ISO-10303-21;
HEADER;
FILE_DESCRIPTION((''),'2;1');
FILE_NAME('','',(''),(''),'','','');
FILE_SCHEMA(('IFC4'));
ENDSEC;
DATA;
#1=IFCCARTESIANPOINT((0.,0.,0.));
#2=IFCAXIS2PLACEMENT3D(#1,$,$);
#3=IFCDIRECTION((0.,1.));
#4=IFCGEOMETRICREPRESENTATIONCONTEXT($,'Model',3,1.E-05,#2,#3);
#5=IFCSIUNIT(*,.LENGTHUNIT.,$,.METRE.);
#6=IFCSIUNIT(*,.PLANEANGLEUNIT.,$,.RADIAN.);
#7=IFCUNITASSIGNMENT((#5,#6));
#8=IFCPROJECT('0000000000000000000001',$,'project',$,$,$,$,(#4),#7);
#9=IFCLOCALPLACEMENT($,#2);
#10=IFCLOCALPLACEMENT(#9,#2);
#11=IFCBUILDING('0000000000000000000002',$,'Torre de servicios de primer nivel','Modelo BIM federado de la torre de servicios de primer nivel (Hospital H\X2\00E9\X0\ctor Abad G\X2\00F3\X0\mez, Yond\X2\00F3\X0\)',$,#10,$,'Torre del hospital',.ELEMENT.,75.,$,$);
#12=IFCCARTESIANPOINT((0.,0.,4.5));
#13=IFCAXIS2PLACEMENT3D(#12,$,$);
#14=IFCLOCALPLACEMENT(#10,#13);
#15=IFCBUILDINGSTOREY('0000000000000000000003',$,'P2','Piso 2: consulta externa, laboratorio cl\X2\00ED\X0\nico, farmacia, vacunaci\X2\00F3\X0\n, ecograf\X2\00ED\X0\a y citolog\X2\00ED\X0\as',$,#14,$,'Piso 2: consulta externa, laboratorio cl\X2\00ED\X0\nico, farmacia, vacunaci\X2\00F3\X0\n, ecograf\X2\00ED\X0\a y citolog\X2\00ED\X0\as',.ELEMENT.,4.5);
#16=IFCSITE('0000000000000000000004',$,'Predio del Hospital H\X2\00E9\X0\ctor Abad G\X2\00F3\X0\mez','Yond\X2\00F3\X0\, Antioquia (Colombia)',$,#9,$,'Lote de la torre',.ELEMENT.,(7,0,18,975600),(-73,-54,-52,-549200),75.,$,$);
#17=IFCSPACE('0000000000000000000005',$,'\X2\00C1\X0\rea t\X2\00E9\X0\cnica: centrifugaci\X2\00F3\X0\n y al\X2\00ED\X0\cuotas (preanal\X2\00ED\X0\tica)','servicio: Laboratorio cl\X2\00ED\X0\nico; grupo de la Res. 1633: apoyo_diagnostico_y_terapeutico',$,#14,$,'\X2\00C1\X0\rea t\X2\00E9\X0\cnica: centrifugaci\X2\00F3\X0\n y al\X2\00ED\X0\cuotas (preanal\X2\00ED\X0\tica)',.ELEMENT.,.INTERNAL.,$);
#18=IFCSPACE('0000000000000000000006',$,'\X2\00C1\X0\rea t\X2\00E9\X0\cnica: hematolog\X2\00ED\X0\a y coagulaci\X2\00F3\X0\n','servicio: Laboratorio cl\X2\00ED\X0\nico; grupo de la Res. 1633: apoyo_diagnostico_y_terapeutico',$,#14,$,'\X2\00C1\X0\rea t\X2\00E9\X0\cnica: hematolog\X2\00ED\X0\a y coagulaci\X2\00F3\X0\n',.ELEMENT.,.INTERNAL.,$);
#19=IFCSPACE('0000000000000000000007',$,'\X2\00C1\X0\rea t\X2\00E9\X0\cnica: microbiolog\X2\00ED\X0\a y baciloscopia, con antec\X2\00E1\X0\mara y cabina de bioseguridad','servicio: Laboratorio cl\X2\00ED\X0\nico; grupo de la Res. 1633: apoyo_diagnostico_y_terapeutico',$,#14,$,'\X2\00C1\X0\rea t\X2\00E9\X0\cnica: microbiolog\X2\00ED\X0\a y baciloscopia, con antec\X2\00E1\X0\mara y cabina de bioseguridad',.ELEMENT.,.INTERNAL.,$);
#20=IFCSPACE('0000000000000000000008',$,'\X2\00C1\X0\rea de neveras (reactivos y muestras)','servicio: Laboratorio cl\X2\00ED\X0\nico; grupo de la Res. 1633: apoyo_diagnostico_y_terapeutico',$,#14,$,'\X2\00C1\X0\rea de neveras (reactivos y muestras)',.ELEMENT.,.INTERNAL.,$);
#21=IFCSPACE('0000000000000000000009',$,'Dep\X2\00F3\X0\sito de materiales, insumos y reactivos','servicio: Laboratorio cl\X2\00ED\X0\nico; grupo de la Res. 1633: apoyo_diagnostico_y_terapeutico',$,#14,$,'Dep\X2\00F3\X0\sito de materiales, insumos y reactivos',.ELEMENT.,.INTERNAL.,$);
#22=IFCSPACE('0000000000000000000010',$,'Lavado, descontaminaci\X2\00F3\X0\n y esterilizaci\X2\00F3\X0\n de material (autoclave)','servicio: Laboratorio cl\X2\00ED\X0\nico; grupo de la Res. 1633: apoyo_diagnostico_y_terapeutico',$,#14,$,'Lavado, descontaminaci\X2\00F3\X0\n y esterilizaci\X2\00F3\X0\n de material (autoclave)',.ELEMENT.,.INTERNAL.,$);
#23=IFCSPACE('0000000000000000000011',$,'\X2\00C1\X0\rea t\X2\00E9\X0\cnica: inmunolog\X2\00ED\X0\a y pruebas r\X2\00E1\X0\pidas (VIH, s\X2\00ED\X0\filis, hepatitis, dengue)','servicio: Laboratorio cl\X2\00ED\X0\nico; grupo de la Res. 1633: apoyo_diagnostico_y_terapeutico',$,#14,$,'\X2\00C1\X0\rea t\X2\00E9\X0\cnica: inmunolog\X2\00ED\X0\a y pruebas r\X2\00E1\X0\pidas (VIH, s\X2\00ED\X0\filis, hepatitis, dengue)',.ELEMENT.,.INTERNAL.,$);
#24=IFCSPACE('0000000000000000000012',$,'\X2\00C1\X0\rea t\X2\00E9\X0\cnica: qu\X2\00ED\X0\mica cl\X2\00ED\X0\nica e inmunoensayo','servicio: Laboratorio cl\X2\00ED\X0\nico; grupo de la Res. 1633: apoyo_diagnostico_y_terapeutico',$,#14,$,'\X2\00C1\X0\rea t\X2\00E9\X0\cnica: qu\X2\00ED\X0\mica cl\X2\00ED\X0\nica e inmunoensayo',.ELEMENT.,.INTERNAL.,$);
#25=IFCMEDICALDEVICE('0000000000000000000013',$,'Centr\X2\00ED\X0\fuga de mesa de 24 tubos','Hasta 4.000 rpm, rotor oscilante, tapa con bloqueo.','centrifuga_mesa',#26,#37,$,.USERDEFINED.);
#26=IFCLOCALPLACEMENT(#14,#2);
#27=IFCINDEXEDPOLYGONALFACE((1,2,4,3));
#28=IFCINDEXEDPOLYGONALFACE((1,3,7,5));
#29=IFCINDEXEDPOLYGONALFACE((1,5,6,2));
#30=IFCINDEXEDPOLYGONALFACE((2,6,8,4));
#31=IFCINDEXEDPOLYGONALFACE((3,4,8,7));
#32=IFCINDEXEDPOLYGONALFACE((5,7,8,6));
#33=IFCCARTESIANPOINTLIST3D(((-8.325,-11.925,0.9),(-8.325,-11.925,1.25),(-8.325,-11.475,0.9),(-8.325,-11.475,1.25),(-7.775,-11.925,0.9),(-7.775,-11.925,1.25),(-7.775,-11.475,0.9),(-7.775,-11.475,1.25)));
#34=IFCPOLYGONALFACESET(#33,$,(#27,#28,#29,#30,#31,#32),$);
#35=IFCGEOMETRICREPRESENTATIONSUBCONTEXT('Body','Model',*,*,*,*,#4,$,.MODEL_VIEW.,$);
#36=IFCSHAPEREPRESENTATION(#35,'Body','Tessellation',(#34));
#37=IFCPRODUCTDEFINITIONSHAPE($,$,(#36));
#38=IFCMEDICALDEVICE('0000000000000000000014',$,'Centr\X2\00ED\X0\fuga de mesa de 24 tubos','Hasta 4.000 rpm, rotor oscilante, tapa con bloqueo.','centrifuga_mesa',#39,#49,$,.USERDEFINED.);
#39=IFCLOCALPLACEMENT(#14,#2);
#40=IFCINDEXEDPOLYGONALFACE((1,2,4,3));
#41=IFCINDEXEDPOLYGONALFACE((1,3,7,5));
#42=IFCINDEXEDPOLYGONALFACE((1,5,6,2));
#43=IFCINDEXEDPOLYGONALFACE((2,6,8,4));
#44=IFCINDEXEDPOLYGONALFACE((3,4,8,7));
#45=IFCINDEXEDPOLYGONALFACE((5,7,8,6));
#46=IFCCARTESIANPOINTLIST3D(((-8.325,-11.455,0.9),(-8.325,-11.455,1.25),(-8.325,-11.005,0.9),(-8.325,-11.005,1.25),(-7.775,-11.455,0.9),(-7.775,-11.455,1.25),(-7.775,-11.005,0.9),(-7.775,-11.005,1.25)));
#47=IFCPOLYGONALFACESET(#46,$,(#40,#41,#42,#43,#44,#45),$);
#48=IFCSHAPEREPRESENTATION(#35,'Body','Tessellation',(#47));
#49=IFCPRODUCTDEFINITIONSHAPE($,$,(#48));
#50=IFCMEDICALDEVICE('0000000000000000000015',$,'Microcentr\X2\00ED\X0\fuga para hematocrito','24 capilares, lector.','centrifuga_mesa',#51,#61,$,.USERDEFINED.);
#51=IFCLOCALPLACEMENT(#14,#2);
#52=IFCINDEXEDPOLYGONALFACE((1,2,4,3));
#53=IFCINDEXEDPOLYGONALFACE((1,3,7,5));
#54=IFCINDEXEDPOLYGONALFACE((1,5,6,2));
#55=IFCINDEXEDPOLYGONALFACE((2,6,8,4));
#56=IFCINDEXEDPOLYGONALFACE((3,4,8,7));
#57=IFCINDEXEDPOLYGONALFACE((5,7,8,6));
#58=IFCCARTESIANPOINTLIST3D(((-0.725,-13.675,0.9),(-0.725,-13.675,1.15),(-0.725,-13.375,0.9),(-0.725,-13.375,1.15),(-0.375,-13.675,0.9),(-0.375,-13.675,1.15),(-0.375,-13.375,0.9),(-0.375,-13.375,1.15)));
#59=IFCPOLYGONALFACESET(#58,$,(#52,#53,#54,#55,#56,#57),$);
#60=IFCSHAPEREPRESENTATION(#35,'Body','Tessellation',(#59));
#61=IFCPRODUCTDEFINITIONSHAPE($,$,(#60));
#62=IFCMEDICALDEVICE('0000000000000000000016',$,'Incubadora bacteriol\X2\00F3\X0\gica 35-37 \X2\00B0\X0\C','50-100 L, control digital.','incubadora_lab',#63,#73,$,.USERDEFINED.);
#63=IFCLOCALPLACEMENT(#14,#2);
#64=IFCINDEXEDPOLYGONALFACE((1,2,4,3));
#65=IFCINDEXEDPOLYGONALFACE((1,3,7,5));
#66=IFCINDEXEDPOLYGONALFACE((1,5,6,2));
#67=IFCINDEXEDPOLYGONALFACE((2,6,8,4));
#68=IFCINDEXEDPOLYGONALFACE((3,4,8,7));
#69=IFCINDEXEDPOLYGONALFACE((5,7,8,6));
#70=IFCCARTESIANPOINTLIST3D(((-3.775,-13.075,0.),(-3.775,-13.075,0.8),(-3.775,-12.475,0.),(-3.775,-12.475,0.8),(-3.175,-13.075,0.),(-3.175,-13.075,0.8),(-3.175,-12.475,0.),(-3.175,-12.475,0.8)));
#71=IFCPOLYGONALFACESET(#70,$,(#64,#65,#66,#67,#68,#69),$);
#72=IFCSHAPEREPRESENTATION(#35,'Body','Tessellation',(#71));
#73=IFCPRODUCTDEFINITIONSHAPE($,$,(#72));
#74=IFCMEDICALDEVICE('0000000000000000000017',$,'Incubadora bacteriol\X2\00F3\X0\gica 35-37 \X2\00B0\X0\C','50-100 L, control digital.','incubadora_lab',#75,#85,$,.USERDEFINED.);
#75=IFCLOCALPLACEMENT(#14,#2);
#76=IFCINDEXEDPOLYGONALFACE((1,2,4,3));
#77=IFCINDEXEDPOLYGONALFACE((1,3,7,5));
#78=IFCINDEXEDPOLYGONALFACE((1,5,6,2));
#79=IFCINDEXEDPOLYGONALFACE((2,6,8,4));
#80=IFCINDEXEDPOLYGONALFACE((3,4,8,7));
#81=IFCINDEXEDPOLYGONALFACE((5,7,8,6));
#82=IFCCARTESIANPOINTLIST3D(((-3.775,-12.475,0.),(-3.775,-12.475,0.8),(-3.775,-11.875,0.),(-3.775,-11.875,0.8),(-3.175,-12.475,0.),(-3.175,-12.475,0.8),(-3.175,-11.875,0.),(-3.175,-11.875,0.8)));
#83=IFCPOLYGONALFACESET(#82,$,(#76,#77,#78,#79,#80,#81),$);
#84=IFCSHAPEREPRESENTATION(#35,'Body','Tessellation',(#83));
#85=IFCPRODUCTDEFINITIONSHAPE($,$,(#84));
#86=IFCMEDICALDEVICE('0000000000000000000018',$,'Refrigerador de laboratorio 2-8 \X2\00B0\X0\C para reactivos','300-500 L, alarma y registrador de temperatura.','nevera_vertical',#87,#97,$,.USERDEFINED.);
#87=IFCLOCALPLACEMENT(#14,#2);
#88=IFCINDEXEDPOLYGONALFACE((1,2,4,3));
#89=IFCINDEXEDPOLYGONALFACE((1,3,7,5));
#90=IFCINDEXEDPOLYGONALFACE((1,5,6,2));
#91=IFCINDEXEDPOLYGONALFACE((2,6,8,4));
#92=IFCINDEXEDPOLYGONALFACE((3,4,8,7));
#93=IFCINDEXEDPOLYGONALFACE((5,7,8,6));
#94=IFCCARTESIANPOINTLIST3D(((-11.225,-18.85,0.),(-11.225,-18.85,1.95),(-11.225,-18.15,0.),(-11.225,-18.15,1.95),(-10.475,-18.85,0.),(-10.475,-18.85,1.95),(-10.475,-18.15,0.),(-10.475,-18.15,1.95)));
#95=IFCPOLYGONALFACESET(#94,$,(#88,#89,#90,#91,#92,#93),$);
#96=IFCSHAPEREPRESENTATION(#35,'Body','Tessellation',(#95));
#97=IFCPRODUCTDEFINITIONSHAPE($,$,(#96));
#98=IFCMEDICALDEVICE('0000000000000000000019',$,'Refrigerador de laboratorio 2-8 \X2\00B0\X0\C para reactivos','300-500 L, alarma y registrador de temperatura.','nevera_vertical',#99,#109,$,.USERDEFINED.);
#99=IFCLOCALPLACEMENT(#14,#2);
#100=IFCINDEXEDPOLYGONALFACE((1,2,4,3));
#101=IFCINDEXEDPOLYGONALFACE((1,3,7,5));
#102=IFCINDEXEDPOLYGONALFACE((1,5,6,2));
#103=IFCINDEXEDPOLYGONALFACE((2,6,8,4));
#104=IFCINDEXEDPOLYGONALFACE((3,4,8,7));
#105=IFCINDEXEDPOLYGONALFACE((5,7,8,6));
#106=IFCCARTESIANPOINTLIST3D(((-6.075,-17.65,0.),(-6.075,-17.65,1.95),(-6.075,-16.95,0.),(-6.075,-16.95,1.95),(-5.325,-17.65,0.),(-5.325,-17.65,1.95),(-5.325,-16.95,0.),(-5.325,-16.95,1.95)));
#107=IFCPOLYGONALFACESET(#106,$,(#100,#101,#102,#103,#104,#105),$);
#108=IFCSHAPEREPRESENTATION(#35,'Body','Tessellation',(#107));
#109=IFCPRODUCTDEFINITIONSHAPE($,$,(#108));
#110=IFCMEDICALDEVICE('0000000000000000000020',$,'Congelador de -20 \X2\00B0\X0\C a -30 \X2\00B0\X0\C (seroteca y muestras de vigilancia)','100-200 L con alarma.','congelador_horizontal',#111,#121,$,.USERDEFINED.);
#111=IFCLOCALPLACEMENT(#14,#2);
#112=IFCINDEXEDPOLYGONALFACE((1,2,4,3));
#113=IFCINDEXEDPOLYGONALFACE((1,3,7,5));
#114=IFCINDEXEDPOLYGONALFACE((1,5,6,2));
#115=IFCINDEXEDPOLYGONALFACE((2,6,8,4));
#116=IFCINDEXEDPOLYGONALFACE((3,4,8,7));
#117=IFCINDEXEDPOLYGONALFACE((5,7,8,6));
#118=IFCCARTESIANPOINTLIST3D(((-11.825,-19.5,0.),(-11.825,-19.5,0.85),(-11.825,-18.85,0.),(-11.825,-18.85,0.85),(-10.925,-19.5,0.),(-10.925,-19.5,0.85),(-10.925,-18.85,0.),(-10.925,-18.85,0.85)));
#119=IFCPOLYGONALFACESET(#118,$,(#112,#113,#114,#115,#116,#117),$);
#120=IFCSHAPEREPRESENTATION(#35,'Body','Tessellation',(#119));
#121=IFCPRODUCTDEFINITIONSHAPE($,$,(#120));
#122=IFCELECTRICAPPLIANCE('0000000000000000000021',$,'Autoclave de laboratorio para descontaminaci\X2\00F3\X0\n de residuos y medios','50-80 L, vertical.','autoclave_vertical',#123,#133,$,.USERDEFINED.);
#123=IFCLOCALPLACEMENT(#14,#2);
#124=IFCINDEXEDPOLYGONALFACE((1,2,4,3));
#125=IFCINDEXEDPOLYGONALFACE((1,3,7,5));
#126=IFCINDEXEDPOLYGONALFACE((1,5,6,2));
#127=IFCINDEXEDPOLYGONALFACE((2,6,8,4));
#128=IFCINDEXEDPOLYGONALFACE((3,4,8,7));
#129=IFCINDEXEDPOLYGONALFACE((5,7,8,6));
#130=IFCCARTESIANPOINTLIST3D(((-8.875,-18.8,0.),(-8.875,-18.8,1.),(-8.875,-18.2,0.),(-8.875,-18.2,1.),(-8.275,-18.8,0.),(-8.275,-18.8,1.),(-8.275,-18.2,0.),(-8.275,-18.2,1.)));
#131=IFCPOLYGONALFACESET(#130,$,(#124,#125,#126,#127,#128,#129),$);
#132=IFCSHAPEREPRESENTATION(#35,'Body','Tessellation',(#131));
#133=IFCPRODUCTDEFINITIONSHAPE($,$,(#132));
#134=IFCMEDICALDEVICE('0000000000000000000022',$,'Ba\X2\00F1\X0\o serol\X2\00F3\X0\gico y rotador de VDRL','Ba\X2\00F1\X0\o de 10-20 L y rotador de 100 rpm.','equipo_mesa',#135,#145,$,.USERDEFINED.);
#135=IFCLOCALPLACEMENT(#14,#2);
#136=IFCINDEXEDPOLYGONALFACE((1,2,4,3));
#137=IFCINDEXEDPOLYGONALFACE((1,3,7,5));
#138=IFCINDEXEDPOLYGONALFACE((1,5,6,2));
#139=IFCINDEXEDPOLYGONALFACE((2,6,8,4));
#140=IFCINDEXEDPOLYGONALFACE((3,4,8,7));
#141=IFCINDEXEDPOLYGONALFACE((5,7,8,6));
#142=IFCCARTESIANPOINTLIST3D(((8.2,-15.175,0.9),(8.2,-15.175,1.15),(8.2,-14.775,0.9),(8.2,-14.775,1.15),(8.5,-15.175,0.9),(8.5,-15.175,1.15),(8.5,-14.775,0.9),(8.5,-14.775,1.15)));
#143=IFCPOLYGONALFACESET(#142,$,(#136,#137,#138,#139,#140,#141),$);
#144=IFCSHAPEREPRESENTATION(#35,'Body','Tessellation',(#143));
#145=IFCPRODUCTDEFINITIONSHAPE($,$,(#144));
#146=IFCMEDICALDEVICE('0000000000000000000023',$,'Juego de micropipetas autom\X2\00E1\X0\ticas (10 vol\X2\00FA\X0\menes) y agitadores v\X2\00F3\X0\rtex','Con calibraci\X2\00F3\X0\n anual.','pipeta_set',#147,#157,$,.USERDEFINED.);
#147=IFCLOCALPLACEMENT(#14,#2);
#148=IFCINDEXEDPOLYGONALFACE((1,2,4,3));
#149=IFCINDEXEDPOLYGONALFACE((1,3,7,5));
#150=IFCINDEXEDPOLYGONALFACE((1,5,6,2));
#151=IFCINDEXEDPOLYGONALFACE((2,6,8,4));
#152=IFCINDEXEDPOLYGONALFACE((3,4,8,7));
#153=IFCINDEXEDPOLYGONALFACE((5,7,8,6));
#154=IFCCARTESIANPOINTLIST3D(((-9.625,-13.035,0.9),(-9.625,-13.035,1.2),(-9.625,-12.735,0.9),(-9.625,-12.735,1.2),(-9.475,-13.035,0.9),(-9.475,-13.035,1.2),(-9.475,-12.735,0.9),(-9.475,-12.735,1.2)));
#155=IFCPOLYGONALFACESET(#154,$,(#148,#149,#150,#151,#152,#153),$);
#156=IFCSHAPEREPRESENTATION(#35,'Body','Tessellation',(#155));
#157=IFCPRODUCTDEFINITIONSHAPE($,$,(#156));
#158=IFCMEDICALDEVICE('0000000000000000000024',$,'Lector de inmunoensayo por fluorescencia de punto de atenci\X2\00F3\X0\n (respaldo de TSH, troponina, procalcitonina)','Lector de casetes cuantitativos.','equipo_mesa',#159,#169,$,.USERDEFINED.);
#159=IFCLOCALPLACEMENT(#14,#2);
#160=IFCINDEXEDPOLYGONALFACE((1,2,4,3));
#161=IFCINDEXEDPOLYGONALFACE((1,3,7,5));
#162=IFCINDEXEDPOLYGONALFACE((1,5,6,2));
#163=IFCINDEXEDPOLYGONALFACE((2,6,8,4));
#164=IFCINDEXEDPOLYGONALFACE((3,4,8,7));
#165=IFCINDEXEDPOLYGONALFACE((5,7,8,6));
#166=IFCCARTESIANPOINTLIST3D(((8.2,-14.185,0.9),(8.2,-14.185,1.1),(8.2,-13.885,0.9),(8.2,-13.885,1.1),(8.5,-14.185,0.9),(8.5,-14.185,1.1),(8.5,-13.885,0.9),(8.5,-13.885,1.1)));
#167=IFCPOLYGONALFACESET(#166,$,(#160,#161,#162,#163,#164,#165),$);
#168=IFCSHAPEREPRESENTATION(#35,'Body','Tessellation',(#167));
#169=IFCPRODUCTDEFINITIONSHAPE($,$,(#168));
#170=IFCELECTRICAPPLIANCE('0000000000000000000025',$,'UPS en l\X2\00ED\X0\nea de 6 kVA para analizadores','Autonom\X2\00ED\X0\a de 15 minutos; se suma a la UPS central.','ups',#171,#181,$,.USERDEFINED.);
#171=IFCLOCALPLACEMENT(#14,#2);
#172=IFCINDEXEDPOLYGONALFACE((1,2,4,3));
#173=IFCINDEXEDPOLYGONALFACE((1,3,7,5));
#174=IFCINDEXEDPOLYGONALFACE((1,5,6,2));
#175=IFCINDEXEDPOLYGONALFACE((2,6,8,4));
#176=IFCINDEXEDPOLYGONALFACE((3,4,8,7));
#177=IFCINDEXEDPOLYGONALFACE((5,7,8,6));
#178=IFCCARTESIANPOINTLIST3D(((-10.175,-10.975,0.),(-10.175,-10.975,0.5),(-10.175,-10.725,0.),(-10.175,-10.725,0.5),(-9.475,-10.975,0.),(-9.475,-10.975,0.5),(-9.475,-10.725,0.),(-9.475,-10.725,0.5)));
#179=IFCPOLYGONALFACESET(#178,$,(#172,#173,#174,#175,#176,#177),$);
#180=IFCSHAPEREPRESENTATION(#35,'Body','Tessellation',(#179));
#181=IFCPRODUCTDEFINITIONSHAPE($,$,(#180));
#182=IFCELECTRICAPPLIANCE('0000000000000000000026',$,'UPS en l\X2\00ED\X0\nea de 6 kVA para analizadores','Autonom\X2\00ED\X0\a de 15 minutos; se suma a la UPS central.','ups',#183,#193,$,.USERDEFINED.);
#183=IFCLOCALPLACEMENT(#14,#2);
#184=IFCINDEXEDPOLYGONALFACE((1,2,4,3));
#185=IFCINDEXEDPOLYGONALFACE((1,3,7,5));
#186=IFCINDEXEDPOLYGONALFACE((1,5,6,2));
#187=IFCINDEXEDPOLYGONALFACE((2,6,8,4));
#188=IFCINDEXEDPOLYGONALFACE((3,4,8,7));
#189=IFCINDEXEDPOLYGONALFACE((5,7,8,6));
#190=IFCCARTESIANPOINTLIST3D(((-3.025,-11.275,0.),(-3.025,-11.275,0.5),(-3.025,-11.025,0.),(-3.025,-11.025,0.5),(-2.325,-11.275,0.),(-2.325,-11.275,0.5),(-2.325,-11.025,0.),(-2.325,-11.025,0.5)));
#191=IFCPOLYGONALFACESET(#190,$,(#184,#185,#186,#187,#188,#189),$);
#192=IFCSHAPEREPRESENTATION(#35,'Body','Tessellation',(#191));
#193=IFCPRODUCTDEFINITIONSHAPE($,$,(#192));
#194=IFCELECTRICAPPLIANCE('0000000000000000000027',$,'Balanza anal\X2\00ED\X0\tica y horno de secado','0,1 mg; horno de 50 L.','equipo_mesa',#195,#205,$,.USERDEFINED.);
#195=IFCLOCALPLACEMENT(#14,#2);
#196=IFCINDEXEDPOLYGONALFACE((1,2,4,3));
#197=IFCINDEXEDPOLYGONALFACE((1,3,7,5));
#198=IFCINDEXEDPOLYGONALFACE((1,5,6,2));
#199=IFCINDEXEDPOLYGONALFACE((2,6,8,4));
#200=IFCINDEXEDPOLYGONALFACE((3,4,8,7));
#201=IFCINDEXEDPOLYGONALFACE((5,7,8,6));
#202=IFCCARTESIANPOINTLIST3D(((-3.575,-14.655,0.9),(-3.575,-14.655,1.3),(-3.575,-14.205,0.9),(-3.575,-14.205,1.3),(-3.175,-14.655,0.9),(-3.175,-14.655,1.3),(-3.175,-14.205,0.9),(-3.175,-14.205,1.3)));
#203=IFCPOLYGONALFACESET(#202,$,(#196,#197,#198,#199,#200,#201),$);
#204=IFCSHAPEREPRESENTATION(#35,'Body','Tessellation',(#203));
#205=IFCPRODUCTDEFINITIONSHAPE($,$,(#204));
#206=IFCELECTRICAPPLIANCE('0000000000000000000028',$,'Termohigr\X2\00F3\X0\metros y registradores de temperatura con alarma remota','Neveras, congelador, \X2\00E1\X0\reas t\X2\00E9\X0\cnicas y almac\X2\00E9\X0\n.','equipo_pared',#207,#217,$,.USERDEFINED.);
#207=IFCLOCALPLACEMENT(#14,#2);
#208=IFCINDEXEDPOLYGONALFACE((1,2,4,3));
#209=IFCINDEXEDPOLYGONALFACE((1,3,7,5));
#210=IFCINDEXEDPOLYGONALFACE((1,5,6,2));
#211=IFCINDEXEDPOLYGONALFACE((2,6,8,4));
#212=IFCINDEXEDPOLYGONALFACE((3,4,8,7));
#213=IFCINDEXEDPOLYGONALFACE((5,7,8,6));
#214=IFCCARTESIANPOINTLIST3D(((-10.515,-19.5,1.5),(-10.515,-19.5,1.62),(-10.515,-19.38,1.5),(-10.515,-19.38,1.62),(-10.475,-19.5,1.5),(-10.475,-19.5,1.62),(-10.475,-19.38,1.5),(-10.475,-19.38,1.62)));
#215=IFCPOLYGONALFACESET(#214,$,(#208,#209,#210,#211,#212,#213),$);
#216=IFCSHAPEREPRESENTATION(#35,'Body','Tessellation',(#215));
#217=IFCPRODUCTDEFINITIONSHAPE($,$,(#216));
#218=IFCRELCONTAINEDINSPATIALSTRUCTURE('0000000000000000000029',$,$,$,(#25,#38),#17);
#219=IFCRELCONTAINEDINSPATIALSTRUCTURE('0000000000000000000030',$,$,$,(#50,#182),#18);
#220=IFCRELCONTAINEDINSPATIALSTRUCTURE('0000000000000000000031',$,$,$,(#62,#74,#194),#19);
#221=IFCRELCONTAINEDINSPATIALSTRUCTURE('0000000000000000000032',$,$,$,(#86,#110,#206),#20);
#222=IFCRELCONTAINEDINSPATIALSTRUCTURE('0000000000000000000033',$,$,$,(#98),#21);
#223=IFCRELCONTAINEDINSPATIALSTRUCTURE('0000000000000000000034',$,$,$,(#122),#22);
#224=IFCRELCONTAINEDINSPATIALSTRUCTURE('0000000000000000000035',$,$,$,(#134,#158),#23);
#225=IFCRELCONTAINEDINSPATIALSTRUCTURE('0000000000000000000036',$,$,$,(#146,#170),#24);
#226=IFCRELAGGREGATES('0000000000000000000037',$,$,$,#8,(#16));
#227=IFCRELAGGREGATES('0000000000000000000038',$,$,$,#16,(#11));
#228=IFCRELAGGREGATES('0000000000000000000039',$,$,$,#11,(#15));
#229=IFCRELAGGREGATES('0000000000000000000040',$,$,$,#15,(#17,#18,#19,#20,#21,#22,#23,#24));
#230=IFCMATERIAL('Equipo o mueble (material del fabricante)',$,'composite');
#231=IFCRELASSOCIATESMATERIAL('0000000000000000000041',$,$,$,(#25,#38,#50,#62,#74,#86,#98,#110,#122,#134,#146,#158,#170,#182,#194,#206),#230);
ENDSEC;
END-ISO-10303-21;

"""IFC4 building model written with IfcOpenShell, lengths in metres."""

from ifc_helpers import new_model, si_unit, direction, frame, origin, place, context, subcontext, project, spatial, rectangle, extrude, material, element, save


model = new_model("IFC4")

# Units and contexts
model_context = context("Model", 3, precision=1e-05, world=origin(), true_north=direction((0.0, 1.0)))
body_context = subcontext(model_context, "Body", "Model", "MODEL_VIEW")
ifc_project = project(units=[si_unit("LENGTHUNIT", "METRE"), si_unit("PLANEANGLEUNIT", "RADIAN")], contexts=[model_context])

# Site, building, storey, space
site_placement = place(None, origin())
site = spatial("IfcSite", under=ifc_project, at=site_placement, Name="Predio del Hospital Héctor Abad Gómez", Description="Yondó, Antioquia (Colombia)", LongName="Lote de la torre", CompositionType="ELEMENT", RefLatitude=(7, 0, 18, 975600), RefLongitude=(-73, -54, -52, -549200), RefElevation=75.0)
building_placement = place(site_placement, origin())
building = spatial("IfcBuilding", under=site, at=building_placement, Name="Torre de servicios de primer nivel", Description="Modelo BIM federado de la torre de servicios de primer nivel (Hospital Héctor Abad Gómez, Yondó)", LongName="Torre del hospital", CompositionType="ELEMENT", ElevationOfRefHeight=75.0)
placement = place(building_placement, frame((0.0, 0.0, 4.5)))
storey = spatial("IfcBuildingStorey", under=building, at=placement, Name="P2", Description="Piso 2: consulta externa, laboratorio clínico, farmacia, vacunación, ecografía y citologías", LongName="Piso 2: consulta externa, laboratorio clínico, farmacia, vacunación, ecografía y citologías", CompositionType="ELEMENT", Elevation=4.5)
space_1 = spatial("IfcSpace", under=storey, at=placement, Name="Área técnica: centrifugación y alícuotas (preanalítica)", Description="servicio: Laboratorio clínico; grupo de la Res. 1633: apoyo_diagnostico_y_terapeutico", LongName="Área técnica: centrifugación y alícuotas (preanalítica)", CompositionType="ELEMENT", PredefinedType="INTERNAL")

# Medical devices
ifc_material = material(Name="Equipo o mueble (material del fabricante)", Category="composite")
element("IfcMedicalDevice", 1, at=placement, inside=space_1, material=ifc_material, Name="Centrífuga de mesa de 24 tubos", Description="Hasta 4.000 rpm, rotor oscilante, tapa con bloqueo.", ObjectType="centrifuga_mesa", PredefinedType="USERDEFINED", context=body_context, shape_type="SweptSolid", body=[
    extrude(rectangle(XDim=0.45, YDim=0.55), frame((-8.05, -11.7, 0.9), z_axis=(0.0, 0.0, 1.0), x_axis=(0.0, 1.0, 0.0)), (0.0, 0.0, 1.0), 0.35),
])
element("IfcMedicalDevice", 2, at=placement, inside=space_1, material=ifc_material, Name="Centrífuga de mesa de 24 tubos", Description="Hasta 4.000 rpm, rotor oscilante, tapa con bloqueo.", ObjectType="centrifuga_mesa", PredefinedType="USERDEFINED", context=body_context, shape_type="SweptSolid", body=[
    extrude(rectangle(XDim=0.45, YDim=0.55), frame((-8.05, -11.23, 0.9), z_axis=(0.0, 0.0, 1.0), x_axis=(0.0, 1.0, 0.0)), (0.0, 0.0, 1.0), 0.35),
])

# Shared definitions
space_2 = spatial("IfcSpace", under=storey, at=placement, Name="Área técnica: hematología y coagulación", Description="servicio: Laboratorio clínico; grupo de la Res. 1633: apoyo_diagnostico_y_terapeutico", LongName="Área técnica: hematología y coagulación", CompositionType="ELEMENT", PredefinedType="INTERNAL")

# Medical device
element("IfcMedicalDevice", 3, at=placement, inside=space_2, material=ifc_material, Name="Microcentrífuga para hematocrito", Description="24 capilares, lector.", ObjectType="centrifuga_mesa", PredefinedType="USERDEFINED", context=body_context, shape_type="SweptSolid", body=[
    extrude(rectangle(XDim=0.3, YDim=0.35), frame((-0.55, -13.525, 0.9), z_axis=(0.0, 0.0, 1.0), x_axis=(0.0, 1.0, 0.0)), (0.0, 0.0, 1.0), 0.25),
])

# Shared definitions
space_3 = spatial("IfcSpace", under=storey, at=placement, Name="Área técnica: microbiología y baciloscopia, con antecámara y cabina de bioseguridad", Description="servicio: Laboratorio clínico; grupo de la Res. 1633: apoyo_diagnostico_y_terapeutico", LongName="Área técnica: microbiología y baciloscopia, con antecámara y cabina de bioseguridad", CompositionType="ELEMENT", PredefinedType="INTERNAL")

# Medical devices
element("IfcMedicalDevice", 4, at=placement, inside=space_3, material=ifc_material, Name="Incubadora bacteriológica 35-37 °C", Description="50-100 L, control digital.", ObjectType="incubadora_lab", PredefinedType="USERDEFINED", context=body_context, shape_type="SweptSolid", body=[
    extrude(rectangle(XDim=0.6, YDim=0.6), frame((-3.475, -12.775, 0.0), z_axis=(0.0, 0.0, 1.0), x_axis=(0.0, 1.0, 0.0)), (0.0, 0.0, 1.0), 0.8),
])
element("IfcMedicalDevice", 5, at=placement, inside=space_3, material=ifc_material, Name="Incubadora bacteriológica 35-37 °C", Description="50-100 L, control digital.", ObjectType="incubadora_lab", PredefinedType="USERDEFINED", context=body_context, shape_type="SweptSolid", body=[
    extrude(rectangle(XDim=0.6, YDim=0.6), frame((-3.475, -12.175, 0.0), z_axis=(0.0, 0.0, 1.0), x_axis=(0.0, 1.0, 0.0)), (0.0, 0.0, 1.0), 0.8),
])

# Shared definitions
space_4 = spatial("IfcSpace", under=storey, at=placement, Name="Área de neveras (reactivos y muestras)", Description="servicio: Laboratorio clínico; grupo de la Res. 1633: apoyo_diagnostico_y_terapeutico", LongName="Área de neveras (reactivos y muestras)", CompositionType="ELEMENT", PredefinedType="INTERNAL")

# Medical device
element("IfcMedicalDevice", 6, at=placement, inside=space_4, material=ifc_material, Name="Refrigerador de laboratorio 2-8 °C para reactivos", Description="300-500 L, alarma y registrador de temperatura.", ObjectType="nevera_vertical", PredefinedType="USERDEFINED", context=body_context, shape_type="SweptSolid", body=[
    extrude(rectangle(XDim=0.7, YDim=0.75), frame((-10.85, -18.5, 0.0), z_axis=(0.0, 0.0, 1.0), x_axis=(0.0, 1.0, 0.0)), (0.0, 0.0, 1.0), 1.95),
])

# Shared definitions
space_5 = spatial("IfcSpace", under=storey, at=placement, Name="Depósito de materiales, insumos y reactivos", Description="servicio: Laboratorio clínico; grupo de la Res. 1633: apoyo_diagnostico_y_terapeutico", LongName="Depósito de materiales, insumos y reactivos", CompositionType="ELEMENT", PredefinedType="INTERNAL")

# Medical devices
element("IfcMedicalDevice", 7, at=placement, inside=space_5, material=ifc_material, Name="Refrigerador de laboratorio 2-8 °C para reactivos", Description="300-500 L, alarma y registrador de temperatura.", ObjectType="nevera_vertical", PredefinedType="USERDEFINED", context=body_context, shape_type="SweptSolid", body=[
    extrude(rectangle(XDim=0.7, YDim=0.75), frame((-5.7, -17.3, 0.0), z_axis=(0.0, 0.0, 1.0), x_axis=(0.0, 1.0, 0.0)), (0.0, 0.0, 1.0), 1.95),
])
element("IfcMedicalDevice", 8, at=placement, inside=space_4, material=ifc_material, Name="Congelador de -20 °C a -30 °C (seroteca y muestras de vigilancia)", Description="100-200 L con alarma.", ObjectType="congelador_horizontal", PredefinedType="USERDEFINED", context=body_context, shape_type="SweptSolid", body=[
    extrude(rectangle(XDim=0.9, YDim=0.65), frame((-11.375, -19.175, 0.0)), (0.0, 0.0, 1.0), 0.85),
])

# Shared definitions
space_6 = spatial("IfcSpace", under=storey, at=placement, Name="Lavado, descontaminación y esterilización de material (autoclave)", Description="servicio: Laboratorio clínico; grupo de la Res. 1633: apoyo_diagnostico_y_terapeutico", LongName="Lavado, descontaminación y esterilización de material (autoclave)", CompositionType="ELEMENT", PredefinedType="INTERNAL")

# Electric appliance
element("IfcElectricAppliance", 9, at=placement, inside=space_6, material=ifc_material, Name="Autoclave de laboratorio para descontaminación de residuos y medios", Description="50-80 L, vertical.", ObjectType="autoclave_vertical", PredefinedType="USERDEFINED", context=body_context, shape_type="SweptSolid", body=[
    extrude(rectangle(XDim=0.6, YDim=0.6), frame((-8.575, -18.5, 0.0), z_axis=(0.0, 0.0, 1.0), x_axis=(0.0, 1.0, 0.0)), (0.0, 0.0, 1.0), 1.0),
])

# Shared definitions
space_7 = spatial("IfcSpace", under=storey, at=placement, Name="Área técnica: inmunología y pruebas rápidas (VIH, sífilis, hepatitis, dengue)", Description="servicio: Laboratorio clínico; grupo de la Res. 1633: apoyo_diagnostico_y_terapeutico", LongName="Área técnica: inmunología y pruebas rápidas (VIH, sífilis, hepatitis, dengue)", CompositionType="ELEMENT", PredefinedType="INTERNAL")

# Medical device
element("IfcMedicalDevice", 10, at=placement, inside=space_7, material=ifc_material, Name="Baño serológico y rotador de VDRL", Description="Baño de 10-20 L y rotador de 100 rpm.", ObjectType="equipo_mesa", PredefinedType="USERDEFINED", context=body_context, shape_type="SweptSolid", body=[
    extrude(rectangle(XDim=0.4, YDim=0.3), frame((8.35, -14.975, 0.9), z_axis=(0.0, 0.0, 1.0), x_axis=(0.0, 1.0, 0.0)), (0.0, 0.0, 1.0), 0.25),
])

# Shared definitions
space_8 = spatial("IfcSpace", under=storey, at=placement, Name="Área técnica: química clínica e inmunoensayo", Description="servicio: Laboratorio clínico; grupo de la Res. 1633: apoyo_diagnostico_y_terapeutico", LongName="Área técnica: química clínica e inmunoensayo", CompositionType="ELEMENT", PredefinedType="INTERNAL")

# Medical devices
element("IfcMedicalDevice", 11, at=placement, inside=space_8, material=ifc_material, Name="Juego de micropipetas automáticas (10 volúmenes) y agitadores vórtex", Description="Con calibración anual.", ObjectType="pipeta_set", PredefinedType="USERDEFINED", context=body_context, shape_type="SweptSolid", body=[
    extrude(rectangle(XDim=0.3, YDim=0.15), frame((-9.55, -12.885, 0.9), z_axis=(0.0, 0.0, 1.0), x_axis=(0.0, 1.0, 0.0)), (0.0, 0.0, 1.0), 0.3),
])
element("IfcMedicalDevice", 12, at=placement, inside=space_7, material=ifc_material, Name="Lector de inmunoensayo por fluorescencia de punto de atención (respaldo de TSH, troponina, procalcitonina)", Description="Lector de casetes cuantitativos.", ObjectType="equipo_mesa", PredefinedType="USERDEFINED", context=body_context, shape_type="SweptSolid", body=[
    extrude(rectangle(XDim=0.3, YDim=0.3), frame((8.35, -14.035, 0.9), z_axis=(0.0, 0.0, 1.0), x_axis=(0.0, 1.0, 0.0)), (0.0, 0.0, 1.0), 0.2),
])

# Electric appliances
element("IfcElectricAppliance", 13, at=placement, inside=space_8, material=ifc_material, Name="UPS en línea de 6 kVA para analizadores", Description="Autonomía de 15 minutos; se suma a la UPS central.", ObjectType="ups", PredefinedType="USERDEFINED", context=body_context, shape_type="SweptSolid", body=[
    extrude(rectangle(XDim=0.25, YDim=0.7), frame((-9.825, -10.85, 0.0), z_axis=(0.0, 0.0, 1.0), x_axis=(0.0, 1.0, 0.0)), (0.0, 0.0, 1.0), 0.5),
])
element("IfcElectricAppliance", 14, at=placement, inside=space_2, material=ifc_material, Name="UPS en línea de 6 kVA para analizadores", Description="Autonomía de 15 minutos; se suma a la UPS central.", ObjectType="ups", PredefinedType="USERDEFINED", context=body_context, shape_type="SweptSolid", body=[
    extrude(rectangle(XDim=0.25, YDim=0.7), frame((-2.675, -11.15, 0.0), z_axis=(0.0, 0.0, 1.0), x_axis=(0.0, -1.0, 0.0)), (0.0, 0.0, 1.0), 0.5),
])
element("IfcElectricAppliance", 15, at=placement, inside=space_3, material=ifc_material, Name="Balanza analítica y horno de secado", Description="0,1 mg; horno de 50 L.", ObjectType="equipo_mesa", PredefinedType="USERDEFINED", context=body_context, shape_type="SweptSolid", body=[
    extrude(rectangle(XDim=0.45, YDim=0.4), frame((-3.375, -14.43, 0.9), z_axis=(0.0, 0.0, 1.0), x_axis=(0.0, 1.0, 0.0)), (0.0, 0.0, 1.0), 0.4),
])
element("IfcElectricAppliance", 16, at=placement, inside=space_4, material=ifc_material, Name="Termohigrómetros y registradores de temperatura con alarma remota", Description="Neveras, congelador, áreas técnicas y almacén.", ObjectType="equipo_pared", PredefinedType="USERDEFINED", context=body_context, shape_type="SweptSolid", body=[
    extrude(rectangle(XDim=0.12, YDim=0.04), frame((-10.495, -19.44, 1.5), z_axis=(0.0, 0.0, 1.0), x_axis=(0.0, 1.0, 0.0)), (0.0, 0.0, 1.0), 0.12),
])

save(model, "model.ifc")
